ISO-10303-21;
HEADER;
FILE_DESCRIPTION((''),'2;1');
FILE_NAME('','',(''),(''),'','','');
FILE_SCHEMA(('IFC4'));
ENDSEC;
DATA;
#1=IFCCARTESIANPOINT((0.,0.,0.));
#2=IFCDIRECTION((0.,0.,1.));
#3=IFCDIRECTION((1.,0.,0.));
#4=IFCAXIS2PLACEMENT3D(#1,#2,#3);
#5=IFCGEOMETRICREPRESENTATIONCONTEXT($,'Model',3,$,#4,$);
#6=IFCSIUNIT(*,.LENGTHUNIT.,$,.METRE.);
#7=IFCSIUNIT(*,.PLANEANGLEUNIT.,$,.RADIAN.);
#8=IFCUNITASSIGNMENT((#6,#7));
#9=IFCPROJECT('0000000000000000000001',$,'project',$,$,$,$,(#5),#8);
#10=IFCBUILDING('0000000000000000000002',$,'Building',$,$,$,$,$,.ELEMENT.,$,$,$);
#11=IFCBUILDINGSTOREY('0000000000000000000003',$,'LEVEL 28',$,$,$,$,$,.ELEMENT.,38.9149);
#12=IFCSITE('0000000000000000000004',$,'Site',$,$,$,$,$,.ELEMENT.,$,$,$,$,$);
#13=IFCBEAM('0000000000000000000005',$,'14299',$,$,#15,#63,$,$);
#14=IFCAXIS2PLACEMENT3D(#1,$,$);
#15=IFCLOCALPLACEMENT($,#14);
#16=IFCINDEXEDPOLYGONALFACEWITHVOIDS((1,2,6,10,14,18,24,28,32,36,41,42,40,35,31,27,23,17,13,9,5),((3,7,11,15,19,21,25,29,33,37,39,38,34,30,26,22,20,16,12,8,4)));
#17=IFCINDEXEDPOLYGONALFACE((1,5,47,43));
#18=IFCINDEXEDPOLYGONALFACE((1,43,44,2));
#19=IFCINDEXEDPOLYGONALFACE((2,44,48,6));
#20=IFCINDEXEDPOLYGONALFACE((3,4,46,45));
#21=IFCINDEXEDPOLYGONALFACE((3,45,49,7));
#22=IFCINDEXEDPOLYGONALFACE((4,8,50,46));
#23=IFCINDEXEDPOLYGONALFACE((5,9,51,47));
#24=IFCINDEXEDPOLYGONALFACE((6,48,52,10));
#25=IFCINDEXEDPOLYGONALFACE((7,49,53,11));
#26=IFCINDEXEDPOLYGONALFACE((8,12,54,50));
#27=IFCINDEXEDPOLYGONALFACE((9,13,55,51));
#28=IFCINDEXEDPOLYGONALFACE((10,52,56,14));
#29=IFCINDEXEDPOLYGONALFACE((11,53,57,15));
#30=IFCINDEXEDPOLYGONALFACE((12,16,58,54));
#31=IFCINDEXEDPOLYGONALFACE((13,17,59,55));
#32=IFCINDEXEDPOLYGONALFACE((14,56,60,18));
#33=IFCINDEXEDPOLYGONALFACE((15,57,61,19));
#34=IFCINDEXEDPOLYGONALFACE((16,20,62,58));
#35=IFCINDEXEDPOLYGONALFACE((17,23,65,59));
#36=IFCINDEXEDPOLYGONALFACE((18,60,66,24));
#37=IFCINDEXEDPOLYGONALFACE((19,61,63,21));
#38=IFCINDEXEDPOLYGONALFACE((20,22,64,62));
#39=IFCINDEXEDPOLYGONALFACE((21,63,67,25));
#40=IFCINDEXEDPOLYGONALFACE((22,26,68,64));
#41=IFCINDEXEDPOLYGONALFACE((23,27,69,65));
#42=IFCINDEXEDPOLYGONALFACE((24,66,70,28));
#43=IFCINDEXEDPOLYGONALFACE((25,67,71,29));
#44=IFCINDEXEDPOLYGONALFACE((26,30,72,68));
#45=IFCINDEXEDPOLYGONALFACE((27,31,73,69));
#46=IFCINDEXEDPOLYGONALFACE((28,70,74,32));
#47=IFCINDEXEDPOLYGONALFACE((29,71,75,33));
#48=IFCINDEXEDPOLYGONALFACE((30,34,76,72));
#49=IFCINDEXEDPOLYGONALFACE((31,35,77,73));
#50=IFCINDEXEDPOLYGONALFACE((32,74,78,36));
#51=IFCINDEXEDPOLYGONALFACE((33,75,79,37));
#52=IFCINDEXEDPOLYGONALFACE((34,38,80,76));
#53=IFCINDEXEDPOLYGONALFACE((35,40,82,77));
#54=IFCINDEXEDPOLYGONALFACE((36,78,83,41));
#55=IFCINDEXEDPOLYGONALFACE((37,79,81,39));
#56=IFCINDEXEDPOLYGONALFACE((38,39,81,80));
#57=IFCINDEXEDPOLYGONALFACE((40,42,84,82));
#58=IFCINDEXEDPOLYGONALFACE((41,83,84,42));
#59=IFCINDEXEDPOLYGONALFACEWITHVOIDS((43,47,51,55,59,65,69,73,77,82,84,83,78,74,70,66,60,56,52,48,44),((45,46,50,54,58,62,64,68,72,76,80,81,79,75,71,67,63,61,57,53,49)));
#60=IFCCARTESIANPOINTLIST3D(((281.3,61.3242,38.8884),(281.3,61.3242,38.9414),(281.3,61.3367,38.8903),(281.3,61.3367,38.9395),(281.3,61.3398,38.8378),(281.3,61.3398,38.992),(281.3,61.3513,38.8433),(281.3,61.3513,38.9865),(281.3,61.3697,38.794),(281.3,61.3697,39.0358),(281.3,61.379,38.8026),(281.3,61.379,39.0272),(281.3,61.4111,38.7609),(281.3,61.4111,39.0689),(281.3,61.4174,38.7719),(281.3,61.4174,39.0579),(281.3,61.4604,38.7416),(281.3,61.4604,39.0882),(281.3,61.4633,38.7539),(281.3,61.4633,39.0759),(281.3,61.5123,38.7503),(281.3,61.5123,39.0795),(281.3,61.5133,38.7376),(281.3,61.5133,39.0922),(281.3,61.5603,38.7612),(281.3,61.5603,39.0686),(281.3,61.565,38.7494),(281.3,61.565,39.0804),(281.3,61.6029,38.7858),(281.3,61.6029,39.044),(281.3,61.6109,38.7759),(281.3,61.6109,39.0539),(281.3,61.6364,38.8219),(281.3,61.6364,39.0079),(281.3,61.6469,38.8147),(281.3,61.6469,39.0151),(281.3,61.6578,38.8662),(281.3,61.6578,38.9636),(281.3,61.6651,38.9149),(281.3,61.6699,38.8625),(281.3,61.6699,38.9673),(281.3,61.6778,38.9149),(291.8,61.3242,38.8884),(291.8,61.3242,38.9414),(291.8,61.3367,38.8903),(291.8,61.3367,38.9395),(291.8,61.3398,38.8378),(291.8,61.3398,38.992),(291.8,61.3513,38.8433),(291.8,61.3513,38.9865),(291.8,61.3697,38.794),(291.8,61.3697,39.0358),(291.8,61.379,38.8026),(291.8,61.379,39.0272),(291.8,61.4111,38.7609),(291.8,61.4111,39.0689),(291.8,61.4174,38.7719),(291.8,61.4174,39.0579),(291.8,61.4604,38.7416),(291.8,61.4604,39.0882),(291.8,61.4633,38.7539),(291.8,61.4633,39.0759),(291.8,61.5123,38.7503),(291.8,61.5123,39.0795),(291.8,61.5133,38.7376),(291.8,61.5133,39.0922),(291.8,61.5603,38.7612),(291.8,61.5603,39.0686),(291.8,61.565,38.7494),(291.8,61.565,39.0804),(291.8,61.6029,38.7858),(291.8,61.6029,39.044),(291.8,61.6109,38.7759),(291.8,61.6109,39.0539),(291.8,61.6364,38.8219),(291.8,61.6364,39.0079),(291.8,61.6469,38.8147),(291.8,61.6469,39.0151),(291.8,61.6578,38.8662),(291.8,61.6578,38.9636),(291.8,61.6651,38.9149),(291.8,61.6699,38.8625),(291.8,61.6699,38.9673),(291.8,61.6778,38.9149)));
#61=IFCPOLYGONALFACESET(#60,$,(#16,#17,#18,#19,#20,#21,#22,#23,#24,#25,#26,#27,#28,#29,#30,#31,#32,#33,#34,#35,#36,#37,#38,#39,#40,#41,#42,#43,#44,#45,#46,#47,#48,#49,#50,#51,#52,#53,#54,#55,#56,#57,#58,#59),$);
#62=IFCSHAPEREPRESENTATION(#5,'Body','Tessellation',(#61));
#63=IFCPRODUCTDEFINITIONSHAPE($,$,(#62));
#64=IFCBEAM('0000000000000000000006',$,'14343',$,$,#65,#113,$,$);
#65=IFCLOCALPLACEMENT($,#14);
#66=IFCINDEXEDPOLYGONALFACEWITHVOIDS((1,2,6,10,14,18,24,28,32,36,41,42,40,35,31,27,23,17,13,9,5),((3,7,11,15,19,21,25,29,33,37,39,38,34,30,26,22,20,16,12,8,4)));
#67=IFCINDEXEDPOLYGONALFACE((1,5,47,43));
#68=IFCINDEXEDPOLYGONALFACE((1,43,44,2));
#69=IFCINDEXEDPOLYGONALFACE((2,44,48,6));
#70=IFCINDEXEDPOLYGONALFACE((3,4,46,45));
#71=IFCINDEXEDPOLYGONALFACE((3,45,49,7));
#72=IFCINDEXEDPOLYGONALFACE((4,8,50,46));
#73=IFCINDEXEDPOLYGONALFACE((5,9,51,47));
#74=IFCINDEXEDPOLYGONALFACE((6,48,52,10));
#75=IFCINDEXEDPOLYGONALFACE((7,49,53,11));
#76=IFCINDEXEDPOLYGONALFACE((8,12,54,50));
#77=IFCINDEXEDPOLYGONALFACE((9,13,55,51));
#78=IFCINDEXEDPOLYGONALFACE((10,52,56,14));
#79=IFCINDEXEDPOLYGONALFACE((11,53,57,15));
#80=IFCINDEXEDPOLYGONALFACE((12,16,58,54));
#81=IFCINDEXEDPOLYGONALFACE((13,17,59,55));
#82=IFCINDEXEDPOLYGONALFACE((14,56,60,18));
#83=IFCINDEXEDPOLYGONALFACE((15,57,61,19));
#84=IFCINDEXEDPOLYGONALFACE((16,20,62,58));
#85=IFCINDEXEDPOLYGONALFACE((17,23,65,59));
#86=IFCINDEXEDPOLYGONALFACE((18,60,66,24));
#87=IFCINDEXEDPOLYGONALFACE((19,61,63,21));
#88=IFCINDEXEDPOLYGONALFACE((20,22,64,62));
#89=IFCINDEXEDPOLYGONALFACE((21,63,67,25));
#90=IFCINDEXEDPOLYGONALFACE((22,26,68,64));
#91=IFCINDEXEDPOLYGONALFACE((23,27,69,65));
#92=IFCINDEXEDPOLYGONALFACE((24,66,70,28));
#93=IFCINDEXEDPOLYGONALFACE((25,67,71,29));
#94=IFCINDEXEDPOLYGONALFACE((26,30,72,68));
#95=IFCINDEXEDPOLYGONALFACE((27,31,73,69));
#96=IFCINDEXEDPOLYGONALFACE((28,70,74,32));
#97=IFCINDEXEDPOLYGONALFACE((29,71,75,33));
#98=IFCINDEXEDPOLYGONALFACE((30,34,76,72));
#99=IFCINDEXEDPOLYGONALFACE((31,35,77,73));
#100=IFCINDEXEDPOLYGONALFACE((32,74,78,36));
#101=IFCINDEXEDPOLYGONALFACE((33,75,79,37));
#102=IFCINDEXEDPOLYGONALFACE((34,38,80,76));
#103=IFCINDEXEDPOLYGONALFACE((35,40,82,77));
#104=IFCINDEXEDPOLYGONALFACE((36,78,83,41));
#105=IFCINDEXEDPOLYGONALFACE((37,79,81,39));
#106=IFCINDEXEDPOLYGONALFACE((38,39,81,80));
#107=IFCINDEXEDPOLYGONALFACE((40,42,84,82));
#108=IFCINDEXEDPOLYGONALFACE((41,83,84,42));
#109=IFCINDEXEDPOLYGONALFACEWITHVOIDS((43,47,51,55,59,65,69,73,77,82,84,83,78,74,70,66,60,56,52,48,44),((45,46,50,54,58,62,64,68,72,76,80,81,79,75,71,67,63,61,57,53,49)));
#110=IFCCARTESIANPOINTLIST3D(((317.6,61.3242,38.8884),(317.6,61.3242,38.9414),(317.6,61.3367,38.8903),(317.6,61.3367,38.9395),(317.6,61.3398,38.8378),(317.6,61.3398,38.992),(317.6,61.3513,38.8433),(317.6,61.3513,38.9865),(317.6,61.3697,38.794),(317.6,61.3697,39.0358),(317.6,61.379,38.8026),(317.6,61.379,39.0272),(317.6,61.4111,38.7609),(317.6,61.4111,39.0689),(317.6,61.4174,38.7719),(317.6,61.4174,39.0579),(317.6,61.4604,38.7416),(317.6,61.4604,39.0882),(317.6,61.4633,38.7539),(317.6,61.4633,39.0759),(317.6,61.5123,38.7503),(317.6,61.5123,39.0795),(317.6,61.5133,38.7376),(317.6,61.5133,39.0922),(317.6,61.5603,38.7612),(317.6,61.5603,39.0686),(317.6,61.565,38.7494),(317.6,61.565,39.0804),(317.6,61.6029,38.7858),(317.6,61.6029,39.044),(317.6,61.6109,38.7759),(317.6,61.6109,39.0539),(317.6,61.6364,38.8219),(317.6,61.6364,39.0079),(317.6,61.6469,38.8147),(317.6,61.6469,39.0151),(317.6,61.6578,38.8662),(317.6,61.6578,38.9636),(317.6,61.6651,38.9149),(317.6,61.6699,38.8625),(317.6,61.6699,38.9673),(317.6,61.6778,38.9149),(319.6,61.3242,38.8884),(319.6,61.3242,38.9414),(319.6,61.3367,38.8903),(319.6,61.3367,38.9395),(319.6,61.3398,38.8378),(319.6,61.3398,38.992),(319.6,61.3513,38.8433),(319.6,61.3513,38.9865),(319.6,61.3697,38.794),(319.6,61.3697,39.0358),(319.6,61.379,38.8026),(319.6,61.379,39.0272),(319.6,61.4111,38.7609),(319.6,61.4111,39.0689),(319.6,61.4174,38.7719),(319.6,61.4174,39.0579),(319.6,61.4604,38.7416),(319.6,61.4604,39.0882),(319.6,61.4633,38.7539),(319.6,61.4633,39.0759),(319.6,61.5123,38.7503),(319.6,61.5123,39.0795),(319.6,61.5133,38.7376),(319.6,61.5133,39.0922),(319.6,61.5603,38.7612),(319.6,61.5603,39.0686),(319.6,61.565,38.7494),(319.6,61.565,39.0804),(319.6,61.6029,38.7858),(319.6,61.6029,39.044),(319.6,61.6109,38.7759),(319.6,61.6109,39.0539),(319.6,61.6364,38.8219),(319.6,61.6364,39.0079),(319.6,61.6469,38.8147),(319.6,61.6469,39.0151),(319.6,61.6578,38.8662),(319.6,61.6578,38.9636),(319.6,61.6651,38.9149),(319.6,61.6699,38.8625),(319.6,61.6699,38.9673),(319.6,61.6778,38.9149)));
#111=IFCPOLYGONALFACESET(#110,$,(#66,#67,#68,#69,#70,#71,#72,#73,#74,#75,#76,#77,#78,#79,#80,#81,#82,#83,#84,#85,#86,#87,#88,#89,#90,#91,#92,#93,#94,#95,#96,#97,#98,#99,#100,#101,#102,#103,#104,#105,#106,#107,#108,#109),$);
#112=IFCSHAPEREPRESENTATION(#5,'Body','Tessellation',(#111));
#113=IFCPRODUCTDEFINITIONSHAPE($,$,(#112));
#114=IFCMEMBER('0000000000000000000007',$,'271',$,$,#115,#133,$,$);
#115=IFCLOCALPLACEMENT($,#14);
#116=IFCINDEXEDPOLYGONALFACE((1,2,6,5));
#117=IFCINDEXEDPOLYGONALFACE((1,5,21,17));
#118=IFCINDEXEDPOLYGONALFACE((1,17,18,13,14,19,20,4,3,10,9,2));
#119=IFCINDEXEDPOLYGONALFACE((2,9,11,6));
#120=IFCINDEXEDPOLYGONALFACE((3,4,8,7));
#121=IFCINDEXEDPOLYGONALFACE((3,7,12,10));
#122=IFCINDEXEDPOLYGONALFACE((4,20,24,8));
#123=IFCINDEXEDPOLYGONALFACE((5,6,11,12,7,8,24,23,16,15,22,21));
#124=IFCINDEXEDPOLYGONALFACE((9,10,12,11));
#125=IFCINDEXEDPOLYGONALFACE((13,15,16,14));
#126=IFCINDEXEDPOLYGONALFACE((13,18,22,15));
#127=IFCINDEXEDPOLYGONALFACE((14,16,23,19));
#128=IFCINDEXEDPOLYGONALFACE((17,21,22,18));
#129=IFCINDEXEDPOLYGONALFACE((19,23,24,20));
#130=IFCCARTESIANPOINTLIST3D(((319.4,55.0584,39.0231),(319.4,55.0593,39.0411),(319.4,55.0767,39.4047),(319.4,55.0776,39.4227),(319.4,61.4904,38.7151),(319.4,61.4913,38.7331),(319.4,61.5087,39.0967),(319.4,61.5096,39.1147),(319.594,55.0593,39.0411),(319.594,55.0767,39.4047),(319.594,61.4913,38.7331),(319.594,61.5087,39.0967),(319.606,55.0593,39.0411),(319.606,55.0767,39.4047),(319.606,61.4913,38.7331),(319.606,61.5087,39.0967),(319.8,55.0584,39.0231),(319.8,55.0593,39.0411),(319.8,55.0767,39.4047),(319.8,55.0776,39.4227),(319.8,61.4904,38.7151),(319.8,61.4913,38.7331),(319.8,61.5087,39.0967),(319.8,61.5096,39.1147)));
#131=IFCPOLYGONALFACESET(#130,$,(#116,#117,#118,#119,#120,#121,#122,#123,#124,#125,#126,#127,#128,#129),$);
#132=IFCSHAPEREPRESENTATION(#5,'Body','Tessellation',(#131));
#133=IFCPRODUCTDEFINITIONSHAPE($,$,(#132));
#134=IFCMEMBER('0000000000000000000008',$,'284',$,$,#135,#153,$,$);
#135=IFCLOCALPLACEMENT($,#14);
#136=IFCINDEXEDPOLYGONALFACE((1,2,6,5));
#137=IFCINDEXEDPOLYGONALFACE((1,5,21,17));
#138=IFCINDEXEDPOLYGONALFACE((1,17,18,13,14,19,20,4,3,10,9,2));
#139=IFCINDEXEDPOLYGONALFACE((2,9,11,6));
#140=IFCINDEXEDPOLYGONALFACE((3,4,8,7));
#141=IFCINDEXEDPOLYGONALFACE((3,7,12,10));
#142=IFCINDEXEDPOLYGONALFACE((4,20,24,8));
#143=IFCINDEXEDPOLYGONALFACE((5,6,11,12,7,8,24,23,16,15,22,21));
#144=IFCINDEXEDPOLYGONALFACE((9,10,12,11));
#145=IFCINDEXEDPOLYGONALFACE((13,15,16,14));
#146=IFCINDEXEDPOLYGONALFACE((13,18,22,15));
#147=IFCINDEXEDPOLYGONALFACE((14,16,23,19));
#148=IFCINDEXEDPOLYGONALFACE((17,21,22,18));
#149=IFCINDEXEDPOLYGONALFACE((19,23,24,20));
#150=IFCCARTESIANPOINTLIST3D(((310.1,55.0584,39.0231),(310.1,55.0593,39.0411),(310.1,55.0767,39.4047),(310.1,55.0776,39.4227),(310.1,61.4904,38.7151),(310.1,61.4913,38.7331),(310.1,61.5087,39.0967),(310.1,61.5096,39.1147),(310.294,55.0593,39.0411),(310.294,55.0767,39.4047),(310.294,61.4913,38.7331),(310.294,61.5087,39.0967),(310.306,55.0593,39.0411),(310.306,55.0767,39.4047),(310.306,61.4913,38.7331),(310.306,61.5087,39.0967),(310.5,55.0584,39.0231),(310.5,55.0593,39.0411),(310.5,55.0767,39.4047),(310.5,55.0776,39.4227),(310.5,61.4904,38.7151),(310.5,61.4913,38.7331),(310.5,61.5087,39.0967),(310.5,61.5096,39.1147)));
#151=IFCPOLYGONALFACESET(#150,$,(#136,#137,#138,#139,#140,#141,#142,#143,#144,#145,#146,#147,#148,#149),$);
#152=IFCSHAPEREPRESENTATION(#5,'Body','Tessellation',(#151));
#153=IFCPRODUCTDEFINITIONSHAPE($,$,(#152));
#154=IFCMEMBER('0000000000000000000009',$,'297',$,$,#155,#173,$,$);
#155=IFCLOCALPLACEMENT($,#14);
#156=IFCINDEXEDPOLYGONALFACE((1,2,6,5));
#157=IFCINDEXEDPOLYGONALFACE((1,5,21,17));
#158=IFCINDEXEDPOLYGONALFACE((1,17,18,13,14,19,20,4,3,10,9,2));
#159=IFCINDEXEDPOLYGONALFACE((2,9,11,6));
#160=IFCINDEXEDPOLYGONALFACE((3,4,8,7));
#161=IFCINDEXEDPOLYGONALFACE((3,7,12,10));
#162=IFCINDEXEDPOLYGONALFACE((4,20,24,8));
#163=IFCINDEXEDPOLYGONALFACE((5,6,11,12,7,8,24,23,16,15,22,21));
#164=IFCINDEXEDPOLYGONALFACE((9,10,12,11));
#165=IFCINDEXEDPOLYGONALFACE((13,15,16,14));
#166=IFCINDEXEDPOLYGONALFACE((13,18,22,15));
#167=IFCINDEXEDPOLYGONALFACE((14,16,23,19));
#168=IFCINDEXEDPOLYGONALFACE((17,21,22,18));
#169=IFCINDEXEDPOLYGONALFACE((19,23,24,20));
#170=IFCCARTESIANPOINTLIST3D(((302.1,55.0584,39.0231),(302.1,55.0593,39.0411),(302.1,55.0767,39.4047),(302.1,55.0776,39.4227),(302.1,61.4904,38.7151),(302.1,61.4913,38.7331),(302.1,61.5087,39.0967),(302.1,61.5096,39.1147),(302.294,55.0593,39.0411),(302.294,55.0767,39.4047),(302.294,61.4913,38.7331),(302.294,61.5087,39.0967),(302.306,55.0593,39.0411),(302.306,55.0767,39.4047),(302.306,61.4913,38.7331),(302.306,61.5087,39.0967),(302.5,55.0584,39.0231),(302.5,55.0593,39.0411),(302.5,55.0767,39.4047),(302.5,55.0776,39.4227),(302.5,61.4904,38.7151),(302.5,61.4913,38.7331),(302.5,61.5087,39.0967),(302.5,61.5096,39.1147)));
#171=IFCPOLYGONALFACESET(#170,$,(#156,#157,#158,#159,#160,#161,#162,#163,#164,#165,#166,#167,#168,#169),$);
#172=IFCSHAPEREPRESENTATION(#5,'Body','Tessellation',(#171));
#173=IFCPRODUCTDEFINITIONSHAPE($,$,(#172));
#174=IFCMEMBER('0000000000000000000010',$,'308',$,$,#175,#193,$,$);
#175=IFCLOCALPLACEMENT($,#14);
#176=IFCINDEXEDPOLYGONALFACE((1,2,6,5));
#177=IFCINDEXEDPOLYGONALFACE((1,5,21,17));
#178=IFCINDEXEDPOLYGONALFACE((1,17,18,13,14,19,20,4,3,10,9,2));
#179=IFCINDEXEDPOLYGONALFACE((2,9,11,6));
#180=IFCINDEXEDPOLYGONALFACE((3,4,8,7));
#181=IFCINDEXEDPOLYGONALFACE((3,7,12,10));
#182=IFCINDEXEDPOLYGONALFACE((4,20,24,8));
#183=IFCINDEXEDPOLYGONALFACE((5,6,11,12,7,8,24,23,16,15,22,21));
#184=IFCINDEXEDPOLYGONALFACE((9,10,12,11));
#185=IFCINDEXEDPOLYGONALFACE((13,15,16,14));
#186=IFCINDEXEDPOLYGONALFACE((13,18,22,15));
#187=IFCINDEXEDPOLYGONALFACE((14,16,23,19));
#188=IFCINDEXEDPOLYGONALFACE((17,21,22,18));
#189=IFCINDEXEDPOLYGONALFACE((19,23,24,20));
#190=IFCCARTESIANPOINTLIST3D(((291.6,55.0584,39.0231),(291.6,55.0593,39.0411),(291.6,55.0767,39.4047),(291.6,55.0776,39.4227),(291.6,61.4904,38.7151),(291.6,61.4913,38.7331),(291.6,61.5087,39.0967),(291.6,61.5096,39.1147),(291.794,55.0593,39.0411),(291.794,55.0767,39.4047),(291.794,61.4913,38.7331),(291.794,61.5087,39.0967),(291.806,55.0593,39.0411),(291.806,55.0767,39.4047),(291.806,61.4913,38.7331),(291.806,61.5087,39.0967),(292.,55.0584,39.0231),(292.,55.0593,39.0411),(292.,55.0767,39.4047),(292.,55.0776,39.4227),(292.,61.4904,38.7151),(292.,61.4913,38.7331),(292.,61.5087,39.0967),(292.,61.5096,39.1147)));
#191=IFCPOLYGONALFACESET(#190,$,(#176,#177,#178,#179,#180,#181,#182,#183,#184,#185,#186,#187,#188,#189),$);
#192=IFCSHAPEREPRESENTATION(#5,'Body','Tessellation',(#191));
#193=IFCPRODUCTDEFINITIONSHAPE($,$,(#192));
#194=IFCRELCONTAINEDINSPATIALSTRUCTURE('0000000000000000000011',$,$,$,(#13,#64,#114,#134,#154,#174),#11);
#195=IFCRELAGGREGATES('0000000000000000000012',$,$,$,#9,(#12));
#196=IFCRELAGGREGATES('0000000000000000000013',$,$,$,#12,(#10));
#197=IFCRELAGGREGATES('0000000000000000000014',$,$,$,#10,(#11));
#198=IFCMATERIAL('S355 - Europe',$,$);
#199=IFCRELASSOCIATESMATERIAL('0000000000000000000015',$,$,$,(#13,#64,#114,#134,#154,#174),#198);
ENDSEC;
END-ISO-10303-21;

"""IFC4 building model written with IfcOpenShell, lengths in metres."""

from ifc_helpers import new_model, si_unit, frame, origin_with_axes, origin_2d_with_axis, place, context, project, spatial, hollow_circle, i_section, extrude, material, material_profile, profile_set, profile_usage, element, save


model = new_model("IFC4")

# Units and contexts
model_context = context("Model", 3, world=origin_with_axes())
ifc_project = project(units=[si_unit("LENGTHUNIT", "METRE"), si_unit("PLANEANGLEUNIT", "RADIAN")], contexts=[model_context])

# Site, building, storey
site = spatial("IfcSite", under=ifc_project, Name="Site", CompositionType="ELEMENT")
building = spatial("IfcBuilding", under=site, Name="Building", CompositionType="ELEMENT")
storey = spatial("IfcBuildingStorey", under=building, Name="LEVEL 28", CompositionType="ELEMENT", Elevation=38.9149)

# Beams
ifc_material = material(Name="S355 - Europe")
ifc_material_profile_1 = material_profile(ifc_material, hollow_circle(Radius=0.1778, WallThickness=0.0127, at=origin_2d_with_axis()))
ifc_profile_set_1 = profile_set([ifc_material_profile_1])
ifc_profile_usage_1 = profile_usage(ifc_profile_set_1, cardinal=10)
beam_1_placement = place(None, frame((281.3, 61.5, 38.9149), z_axis=(1.0, 0.0, 0.0), x_axis=(0.0, 1.0, 0.0)))
element("IfcBeam", 1, at=beam_1_placement, inside=storey, material=ifc_profile_usage_1, Name="14299", context=model_context, shape_type="SweptSolid", body=[
    extrude(hollow_circle(Radius=0.1778, WallThickness=0.0127, at=origin_2d_with_axis()), origin_with_axes(), (0.0, 0.0, 1.0), 10.5),
])
ifc_material_profile_2 = material_profile(ifc_material, hollow_circle(Radius=0.1778, WallThickness=0.0127, at=origin_2d_with_axis()))
ifc_profile_set_2 = profile_set([ifc_material_profile_2])
ifc_profile_usage_2 = profile_usage(ifc_profile_set_2, cardinal=10)
beam_2_placement = place(None, frame((317.6, 61.5, 38.9149), z_axis=(1.0, 0.0, 0.0), x_axis=(0.0, 1.0, 0.0)))
element("IfcBeam", 2, at=beam_2_placement, inside=storey, material=ifc_profile_usage_2, Name="14343", context=model_context, shape_type="SweptSolid", body=[
    extrude(hollow_circle(Radius=0.1778, WallThickness=0.0127, at=origin_2d_with_axis()), origin_with_axes(), (0.0, 0.0, 1.0), 2.0),
])

# Members
ifc_material_profile_3 = material_profile(ifc_material, i_section(OverallWidth=0.4, OverallDepth=0.4, WebThickness=0.012, FlangeThickness=0.018, at=origin_2d_with_axis()))
ifc_profile_set_3 = profile_set([ifc_material_profile_3])
ifc_profile_usage_3 = profile_usage(ifc_profile_set_3, cardinal=10)
member_1_placement = place(None, frame((319.6, 61.5, 38.9149), z_axis=(0.0, -0.998856, 0.047828), x_axis=(1.0, 0.0, 0.0)))
element("IfcMember", 3, at=member_1_placement, inside=storey, material=ifc_profile_usage_3, Name="271", context=model_context, shape_type="SweptSolid", body=[
    extrude(i_section(OverallWidth=0.4, OverallDepth=0.4, WebThickness=0.012, FlangeThickness=0.018, at=origin_2d_with_axis()), origin_with_axes(), (0.0, 0.0, 1.0), 6.4394),
])
ifc_material_profile_4 = material_profile(ifc_material, i_section(OverallWidth=0.4, OverallDepth=0.4, WebThickness=0.012, FlangeThickness=0.018, at=origin_2d_with_axis()))
ifc_profile_set_4 = profile_set([ifc_material_profile_4])
ifc_profile_usage_4 = profile_usage(ifc_profile_set_4, cardinal=10)
member_2_placement = place(None, frame((310.3, 61.5, 38.9149), z_axis=(0.0, -0.998856, 0.047828), x_axis=(1.0, 0.0, 0.0)))
element("IfcMember", 4, at=member_2_placement, inside=storey, material=ifc_profile_usage_4, Name="284", context=model_context, shape_type="SweptSolid", body=[
    extrude(i_section(OverallWidth=0.4, OverallDepth=0.4, WebThickness=0.012, FlangeThickness=0.018, at=origin_2d_with_axis()), origin_with_axes(), (0.0, 0.0, 1.0), 6.4394),
])
ifc_material_profile_5 = material_profile(ifc_material, i_section(OverallWidth=0.4, OverallDepth=0.4, WebThickness=0.012, FlangeThickness=0.018, at=origin_2d_with_axis()))
ifc_profile_set_5 = profile_set([ifc_material_profile_5])
ifc_profile_usage_5 = profile_usage(ifc_profile_set_5, cardinal=10)
member_3_placement = place(None, frame((302.3, 61.5, 38.9149), z_axis=(0.0, -0.998856, 0.047828), x_axis=(1.0, 0.0, 0.0)))
element("IfcMember", 5, at=member_3_placement, inside=storey, material=ifc_profile_usage_5, Name="297", context=model_context, shape_type="SweptSolid", body=[
    extrude(i_section(OverallWidth=0.4, OverallDepth=0.4, WebThickness=0.012, FlangeThickness=0.018, at=origin_2d_with_axis()), origin_with_axes(), (0.0, 0.0, 1.0), 6.4394),
])
ifc_material_profile_6 = material_profile(ifc_material, i_section(OverallWidth=0.4, OverallDepth=0.4, WebThickness=0.012, FlangeThickness=0.018, at=origin_2d_with_axis()))
ifc_profile_set_6 = profile_set([ifc_material_profile_6])
ifc_profile_usage_6 = profile_usage(ifc_profile_set_6, cardinal=10)
member_4_placement = place(None, frame((291.8, 61.5, 38.9149), z_axis=(0.0, -0.998856, 0.047828), x_axis=(1.0, 0.0, 0.0)))
element("IfcMember", 6, at=member_4_placement, inside=storey, material=ifc_profile_usage_6, Name="308", context=model_context, shape_type="SweptSolid", body=[
    extrude(i_section(OverallWidth=0.4, OverallDepth=0.4, WebThickness=0.012, FlangeThickness=0.018, at=origin_2d_with_axis()), origin_with_axes(), (0.0, 0.0, 1.0), 6.4394),
])

save(model, "model.ifc")
